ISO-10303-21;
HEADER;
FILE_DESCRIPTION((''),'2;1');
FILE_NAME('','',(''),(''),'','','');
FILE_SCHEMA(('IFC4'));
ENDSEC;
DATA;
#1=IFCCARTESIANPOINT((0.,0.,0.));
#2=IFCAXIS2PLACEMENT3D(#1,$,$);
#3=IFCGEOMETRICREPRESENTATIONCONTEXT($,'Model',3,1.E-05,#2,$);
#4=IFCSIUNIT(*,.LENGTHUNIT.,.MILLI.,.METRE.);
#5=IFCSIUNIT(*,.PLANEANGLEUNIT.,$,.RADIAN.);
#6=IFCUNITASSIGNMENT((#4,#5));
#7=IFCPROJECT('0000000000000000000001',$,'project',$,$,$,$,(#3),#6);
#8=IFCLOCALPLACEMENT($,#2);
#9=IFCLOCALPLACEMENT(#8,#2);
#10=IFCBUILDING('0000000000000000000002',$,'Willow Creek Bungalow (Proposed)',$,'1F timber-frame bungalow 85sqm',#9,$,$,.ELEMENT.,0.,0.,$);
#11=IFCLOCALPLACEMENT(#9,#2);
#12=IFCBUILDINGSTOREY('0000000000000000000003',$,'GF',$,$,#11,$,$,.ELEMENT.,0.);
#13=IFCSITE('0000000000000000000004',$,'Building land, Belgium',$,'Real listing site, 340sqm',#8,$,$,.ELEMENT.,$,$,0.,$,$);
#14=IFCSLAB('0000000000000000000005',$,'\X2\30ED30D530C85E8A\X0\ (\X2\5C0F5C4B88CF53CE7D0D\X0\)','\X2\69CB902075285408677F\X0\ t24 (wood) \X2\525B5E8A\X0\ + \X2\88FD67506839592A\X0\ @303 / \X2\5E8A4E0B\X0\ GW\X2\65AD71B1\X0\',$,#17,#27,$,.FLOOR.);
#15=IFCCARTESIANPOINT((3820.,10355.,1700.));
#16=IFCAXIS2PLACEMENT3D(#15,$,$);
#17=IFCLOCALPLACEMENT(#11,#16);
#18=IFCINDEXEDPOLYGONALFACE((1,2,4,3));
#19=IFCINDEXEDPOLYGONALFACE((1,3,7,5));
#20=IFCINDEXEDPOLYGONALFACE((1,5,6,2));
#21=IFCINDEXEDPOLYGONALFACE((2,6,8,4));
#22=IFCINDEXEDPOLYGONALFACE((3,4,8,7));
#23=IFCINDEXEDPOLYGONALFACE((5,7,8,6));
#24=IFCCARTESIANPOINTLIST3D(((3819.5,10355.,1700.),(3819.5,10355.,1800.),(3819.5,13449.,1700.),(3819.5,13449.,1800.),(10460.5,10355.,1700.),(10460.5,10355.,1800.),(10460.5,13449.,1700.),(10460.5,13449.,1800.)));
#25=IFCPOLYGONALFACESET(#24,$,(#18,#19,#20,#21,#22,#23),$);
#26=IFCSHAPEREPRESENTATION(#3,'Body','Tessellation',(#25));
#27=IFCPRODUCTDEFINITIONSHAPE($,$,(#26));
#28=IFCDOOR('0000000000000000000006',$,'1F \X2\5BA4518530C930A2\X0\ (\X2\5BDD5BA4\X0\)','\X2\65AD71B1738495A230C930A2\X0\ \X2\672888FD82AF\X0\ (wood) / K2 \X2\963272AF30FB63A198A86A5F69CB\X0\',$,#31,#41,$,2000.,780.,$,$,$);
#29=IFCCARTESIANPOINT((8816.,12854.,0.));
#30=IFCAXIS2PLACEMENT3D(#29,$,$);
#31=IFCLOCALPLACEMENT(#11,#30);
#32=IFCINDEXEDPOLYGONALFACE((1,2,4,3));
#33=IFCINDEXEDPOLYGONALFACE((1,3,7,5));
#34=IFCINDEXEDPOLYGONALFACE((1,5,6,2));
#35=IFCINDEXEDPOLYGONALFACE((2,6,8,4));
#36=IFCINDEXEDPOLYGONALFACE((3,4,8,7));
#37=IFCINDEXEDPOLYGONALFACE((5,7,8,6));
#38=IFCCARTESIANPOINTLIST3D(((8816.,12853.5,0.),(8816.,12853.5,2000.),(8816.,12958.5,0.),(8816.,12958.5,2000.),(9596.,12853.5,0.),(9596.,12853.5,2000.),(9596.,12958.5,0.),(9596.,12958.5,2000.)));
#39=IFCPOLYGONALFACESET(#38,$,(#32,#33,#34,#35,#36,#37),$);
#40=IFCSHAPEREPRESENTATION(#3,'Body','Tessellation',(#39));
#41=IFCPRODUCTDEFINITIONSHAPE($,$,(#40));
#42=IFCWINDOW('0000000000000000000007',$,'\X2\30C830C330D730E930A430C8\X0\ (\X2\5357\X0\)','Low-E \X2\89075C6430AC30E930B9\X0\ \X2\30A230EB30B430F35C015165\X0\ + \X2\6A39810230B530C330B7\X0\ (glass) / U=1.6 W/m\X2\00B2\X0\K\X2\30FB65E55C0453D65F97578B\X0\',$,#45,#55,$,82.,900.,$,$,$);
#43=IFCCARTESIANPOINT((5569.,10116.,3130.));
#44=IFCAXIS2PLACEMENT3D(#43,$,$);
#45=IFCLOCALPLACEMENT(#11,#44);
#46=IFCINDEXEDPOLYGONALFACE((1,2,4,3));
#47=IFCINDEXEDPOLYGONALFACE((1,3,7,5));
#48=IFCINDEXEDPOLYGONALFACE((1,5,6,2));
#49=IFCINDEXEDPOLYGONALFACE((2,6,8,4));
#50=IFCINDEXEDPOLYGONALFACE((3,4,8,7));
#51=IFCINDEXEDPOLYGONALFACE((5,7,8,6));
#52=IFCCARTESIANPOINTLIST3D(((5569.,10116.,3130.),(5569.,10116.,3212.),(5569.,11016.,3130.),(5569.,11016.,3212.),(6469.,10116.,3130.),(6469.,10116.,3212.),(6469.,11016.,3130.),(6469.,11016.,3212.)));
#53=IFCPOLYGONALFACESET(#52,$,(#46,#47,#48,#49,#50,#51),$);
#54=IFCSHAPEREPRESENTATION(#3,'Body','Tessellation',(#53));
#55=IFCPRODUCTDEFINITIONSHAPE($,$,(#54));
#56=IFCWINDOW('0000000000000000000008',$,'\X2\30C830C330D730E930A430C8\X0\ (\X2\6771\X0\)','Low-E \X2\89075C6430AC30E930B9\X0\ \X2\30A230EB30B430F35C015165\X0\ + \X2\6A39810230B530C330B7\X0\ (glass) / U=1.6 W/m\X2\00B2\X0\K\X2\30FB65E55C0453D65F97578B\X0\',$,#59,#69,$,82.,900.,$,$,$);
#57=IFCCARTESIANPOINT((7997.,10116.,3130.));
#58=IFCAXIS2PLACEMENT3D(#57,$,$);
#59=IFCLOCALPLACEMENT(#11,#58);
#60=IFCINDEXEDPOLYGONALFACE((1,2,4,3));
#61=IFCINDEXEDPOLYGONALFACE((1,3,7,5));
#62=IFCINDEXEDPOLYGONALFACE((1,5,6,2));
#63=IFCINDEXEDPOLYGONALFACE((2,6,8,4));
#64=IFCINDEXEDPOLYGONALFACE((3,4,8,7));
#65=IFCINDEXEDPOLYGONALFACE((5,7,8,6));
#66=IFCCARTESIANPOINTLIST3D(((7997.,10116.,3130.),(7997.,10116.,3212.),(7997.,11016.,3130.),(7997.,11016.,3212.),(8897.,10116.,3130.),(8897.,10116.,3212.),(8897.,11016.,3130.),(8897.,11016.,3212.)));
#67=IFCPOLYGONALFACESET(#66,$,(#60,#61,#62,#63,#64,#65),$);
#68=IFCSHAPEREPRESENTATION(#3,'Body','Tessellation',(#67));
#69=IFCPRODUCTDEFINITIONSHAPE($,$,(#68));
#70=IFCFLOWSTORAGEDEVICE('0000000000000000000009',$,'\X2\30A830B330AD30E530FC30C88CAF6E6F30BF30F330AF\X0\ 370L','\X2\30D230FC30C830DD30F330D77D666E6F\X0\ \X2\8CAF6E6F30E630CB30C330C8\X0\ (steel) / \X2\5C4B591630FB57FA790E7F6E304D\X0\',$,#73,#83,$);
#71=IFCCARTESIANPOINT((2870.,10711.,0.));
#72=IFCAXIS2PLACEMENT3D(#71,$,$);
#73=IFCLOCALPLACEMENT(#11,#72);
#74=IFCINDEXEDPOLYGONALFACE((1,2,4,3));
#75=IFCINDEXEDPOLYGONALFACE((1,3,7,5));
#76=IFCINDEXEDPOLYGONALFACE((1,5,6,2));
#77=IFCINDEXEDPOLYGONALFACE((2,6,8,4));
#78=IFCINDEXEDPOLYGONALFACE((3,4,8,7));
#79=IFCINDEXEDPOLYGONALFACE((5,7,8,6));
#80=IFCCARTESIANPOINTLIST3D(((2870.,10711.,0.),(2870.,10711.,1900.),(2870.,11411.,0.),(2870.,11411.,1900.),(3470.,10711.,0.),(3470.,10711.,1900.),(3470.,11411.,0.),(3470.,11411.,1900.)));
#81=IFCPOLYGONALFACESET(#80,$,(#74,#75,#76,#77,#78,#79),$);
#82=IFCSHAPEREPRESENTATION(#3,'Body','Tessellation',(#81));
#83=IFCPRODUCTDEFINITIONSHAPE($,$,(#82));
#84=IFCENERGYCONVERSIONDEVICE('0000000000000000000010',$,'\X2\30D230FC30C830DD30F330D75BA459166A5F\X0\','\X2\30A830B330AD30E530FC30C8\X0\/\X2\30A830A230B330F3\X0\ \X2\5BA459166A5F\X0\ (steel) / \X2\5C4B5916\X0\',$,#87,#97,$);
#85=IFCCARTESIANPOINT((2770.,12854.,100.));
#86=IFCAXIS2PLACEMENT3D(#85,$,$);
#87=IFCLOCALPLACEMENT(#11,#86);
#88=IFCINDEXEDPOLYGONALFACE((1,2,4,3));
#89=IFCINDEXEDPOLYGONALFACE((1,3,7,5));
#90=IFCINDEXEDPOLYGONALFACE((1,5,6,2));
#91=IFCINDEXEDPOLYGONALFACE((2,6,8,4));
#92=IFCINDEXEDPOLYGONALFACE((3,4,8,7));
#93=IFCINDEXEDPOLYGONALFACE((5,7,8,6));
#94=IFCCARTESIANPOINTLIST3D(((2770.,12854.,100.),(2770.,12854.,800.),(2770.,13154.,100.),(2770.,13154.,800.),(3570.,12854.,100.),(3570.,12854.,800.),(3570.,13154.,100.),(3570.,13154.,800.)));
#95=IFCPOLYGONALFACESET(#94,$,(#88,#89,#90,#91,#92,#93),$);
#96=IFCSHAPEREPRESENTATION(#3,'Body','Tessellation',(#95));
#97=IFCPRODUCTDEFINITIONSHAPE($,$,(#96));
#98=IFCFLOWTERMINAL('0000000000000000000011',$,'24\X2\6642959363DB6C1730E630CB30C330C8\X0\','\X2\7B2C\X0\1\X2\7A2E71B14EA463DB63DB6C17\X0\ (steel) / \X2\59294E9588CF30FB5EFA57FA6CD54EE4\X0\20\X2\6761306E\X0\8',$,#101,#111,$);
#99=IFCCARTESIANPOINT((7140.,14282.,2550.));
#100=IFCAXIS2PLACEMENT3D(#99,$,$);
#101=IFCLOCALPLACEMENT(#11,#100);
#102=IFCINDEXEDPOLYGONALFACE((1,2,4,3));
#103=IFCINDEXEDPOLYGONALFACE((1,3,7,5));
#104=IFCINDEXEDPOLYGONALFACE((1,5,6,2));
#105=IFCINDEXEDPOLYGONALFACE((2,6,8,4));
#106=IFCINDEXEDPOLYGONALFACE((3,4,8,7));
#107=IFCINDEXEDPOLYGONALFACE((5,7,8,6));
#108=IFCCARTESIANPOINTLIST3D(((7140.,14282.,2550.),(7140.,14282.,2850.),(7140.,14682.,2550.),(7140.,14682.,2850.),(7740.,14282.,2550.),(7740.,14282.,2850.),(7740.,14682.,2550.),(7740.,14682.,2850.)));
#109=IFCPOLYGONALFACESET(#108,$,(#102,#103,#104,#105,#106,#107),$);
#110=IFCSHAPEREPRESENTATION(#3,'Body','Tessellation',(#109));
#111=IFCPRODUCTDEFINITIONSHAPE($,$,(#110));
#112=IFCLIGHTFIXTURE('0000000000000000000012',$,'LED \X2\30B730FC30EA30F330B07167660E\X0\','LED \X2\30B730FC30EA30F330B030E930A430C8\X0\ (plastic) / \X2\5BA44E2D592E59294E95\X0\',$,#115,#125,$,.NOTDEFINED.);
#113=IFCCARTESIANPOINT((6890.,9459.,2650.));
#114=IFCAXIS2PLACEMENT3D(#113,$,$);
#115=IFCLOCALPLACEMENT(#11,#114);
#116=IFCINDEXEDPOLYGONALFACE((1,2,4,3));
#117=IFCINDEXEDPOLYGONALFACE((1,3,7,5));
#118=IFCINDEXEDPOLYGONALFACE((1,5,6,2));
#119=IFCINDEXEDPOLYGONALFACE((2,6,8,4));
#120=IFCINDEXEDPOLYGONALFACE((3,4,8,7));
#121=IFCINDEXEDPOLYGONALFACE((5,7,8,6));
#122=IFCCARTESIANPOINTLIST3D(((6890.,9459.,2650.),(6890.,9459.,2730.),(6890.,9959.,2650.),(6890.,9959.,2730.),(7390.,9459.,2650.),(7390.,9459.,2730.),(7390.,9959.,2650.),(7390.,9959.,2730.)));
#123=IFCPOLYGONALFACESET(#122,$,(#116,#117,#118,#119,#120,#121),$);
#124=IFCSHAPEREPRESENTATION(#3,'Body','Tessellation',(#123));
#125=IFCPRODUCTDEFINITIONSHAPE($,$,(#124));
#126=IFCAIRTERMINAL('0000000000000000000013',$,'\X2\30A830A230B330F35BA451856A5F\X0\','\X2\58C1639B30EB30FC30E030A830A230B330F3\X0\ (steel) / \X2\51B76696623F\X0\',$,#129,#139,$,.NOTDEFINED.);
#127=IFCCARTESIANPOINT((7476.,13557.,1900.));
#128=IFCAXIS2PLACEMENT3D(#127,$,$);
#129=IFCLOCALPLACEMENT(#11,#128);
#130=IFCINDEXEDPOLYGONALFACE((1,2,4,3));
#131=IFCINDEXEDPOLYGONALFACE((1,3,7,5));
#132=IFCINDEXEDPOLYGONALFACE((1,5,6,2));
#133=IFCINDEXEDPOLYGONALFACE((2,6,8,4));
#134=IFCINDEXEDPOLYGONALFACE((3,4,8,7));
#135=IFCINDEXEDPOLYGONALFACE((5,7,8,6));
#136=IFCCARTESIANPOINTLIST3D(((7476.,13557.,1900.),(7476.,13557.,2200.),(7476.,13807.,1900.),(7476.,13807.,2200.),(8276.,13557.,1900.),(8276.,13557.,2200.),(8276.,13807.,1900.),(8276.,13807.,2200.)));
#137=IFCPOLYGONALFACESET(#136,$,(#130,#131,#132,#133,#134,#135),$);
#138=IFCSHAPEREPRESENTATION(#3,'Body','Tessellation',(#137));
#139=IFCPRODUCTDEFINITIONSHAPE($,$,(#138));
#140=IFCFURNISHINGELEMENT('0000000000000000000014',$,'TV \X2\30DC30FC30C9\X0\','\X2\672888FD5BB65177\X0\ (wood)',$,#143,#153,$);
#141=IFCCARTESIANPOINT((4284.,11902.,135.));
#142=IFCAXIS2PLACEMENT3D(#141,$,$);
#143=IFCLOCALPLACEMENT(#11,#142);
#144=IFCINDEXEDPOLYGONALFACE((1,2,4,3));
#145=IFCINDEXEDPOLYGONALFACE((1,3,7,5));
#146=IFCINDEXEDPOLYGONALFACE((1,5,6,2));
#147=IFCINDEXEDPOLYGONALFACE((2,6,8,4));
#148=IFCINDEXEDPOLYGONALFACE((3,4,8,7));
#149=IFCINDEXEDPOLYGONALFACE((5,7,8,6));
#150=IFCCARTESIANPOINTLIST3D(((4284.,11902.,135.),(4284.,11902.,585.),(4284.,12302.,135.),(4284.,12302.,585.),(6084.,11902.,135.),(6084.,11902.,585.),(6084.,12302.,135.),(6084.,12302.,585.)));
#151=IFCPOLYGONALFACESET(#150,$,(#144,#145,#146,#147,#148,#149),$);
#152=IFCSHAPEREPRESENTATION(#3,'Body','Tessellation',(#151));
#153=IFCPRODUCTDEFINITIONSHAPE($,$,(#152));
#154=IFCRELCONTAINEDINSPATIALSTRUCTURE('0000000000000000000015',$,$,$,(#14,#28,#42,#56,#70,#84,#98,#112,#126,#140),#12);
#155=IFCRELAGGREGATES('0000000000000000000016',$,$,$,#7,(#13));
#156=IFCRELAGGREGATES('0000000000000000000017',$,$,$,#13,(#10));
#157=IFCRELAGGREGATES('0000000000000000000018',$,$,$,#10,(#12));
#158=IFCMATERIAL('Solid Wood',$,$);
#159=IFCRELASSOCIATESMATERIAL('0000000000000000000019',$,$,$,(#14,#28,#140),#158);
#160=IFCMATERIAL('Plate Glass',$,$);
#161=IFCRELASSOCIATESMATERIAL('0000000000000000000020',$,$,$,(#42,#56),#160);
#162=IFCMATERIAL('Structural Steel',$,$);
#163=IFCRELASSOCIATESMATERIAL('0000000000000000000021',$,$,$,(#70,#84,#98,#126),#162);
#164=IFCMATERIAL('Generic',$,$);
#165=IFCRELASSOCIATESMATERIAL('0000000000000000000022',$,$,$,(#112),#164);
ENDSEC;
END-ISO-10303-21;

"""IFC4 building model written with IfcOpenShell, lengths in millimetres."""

from ifc_helpers import new_model, si_unit, frame, frame_2d, origin, place, context, project, spatial, rectangle, extrude, material, element, save


model = new_model("IFC4")

# Units and contexts
model_context = context("Model", 3, precision=1e-05, world=origin())
ifc_project = project(units=[si_unit("LENGTHUNIT", "METRE", prefix="MILLI"), si_unit("PLANEANGLEUNIT", "RADIAN")], contexts=[model_context])

# Site, building, storey
site_placement = place(None, origin())
site = spatial("IfcSite", under=ifc_project, at=site_placement, Name="Building land, Belgium", ObjectType="Real listing site, 340sqm", CompositionType="ELEMENT", RefElevation=0.0)
building_placement = place(site_placement, origin())
building = spatial("IfcBuilding", under=site, at=building_placement, Name="Willow Creek Bungalow (Proposed)", ObjectType="1F timber-frame bungalow 85sqm", CompositionType="ELEMENT", ElevationOfRefHeight=0.0, ElevationOfTerrain=0.0)
storey_placement = place(building_placement, origin())
storey = spatial("IfcBuildingStorey", under=building, at=storey_placement, Name="GF", CompositionType="ELEMENT", Elevation=0.0)

# Shared definitions
ifc_material_1 = material(Name="Solid Wood")

# Slab
slab_placement = place(storey_placement, frame((3820.0, 10355.0, 1700.0)))
element("IfcSlab", 1, at=slab_placement, inside=storey, material=ifc_material_1, Name="ロフト床 (小屋裏収納)", Description="構造用合板 t24 (wood) 剛床 + 製材根太 @303 / 床下 GW断熱", PredefinedType="FLOOR", context=model_context, shape_type="SweptSolid", body=[
    extrude(rectangle(XDim=6641.0, YDim=3094.0, at=frame_2d((3320.0, 1547.0))), frame((3820.0, 10355.0, 1700.0)), (0.0, 0.0, 1.0), 100.0),
])

# Door
door_1_placement = place(storey_placement, frame((8816.0, 12854.0, 0.0)))
element("IfcDoor", 2, at=door_1_placement, inside=storey, material=ifc_material_1, Name="1F 室内ドア (寝室)", Description="断熱玄関ドア 木製芯 (wood) / K2 防犯・採風機構", OverallHeight=2000.0, OverallWidth=780.0, context=model_context, shape_type="SweptSolid", body=[
    extrude(rectangle(XDim=780.0, YDim=105.0, at=frame_2d((390.0, 52.0))), frame((8816.0, 12854.0, 0.0)), (0.0, 0.0, 1.0), 2000.0),
])

# Windows
ifc_material_2 = material(Name="Plate Glass")
window_1_placement = place(storey_placement, frame((5569.0, 10116.0, 3130.0)))
element("IfcWindow", 3, at=window_1_placement, inside=storey, material=ifc_material_2, Name="トップライト (南)", Description="Low-E 複層ガラス アルゴン封入 + 樹脂サッシ (glass) / U=1.6 W/m²K・日射取得型", OverallHeight=82.0, OverallWidth=900.0, context=model_context, shape_type="SweptSolid", body=[
    extrude(rectangle(XDim=900.0, YDim=900.0, at=frame_2d((450.0, 450.0))), frame((5569.0, 10116.0, 3130.0)), (0.0, 0.0, 1.0), 82.0),
])
window_2_placement = place(storey_placement, frame((7997.0, 10116.0, 3130.0)))
element("IfcWindow", 4, at=window_2_placement, inside=storey, material=ifc_material_2, Name="トップライト (東)", Description="Low-E 複層ガラス アルゴン封入 + 樹脂サッシ (glass) / U=1.6 W/m²K・日射取得型", OverallHeight=82.0, OverallWidth=900.0, context=model_context, shape_type="SweptSolid", body=[
    extrude(rectangle(XDim=900.0, YDim=900.0, at=frame_2d((450.0, 450.0))), frame((7997.0, 10116.0, 3130.0)), (0.0, 0.0, 1.0), 82.0),
])

# Flow storage device
ifc_material_3 = material(Name="Structural Steel")
flow_storage_device_placement = place(storey_placement, frame((2870.0, 10711.0, 0.0)))
element("IfcFlowStorageDevice", 5, at=flow_storage_device_placement, inside=storey, material=ifc_material_3, Name="エコキュート貯湯タンク 370L", Description="ヒートポンプ給湯 貯湯ユニット (steel) / 屋外・基礎置き", context=model_context, shape_type="SweptSolid", body=[
    extrude(rectangle(XDim=600.0, YDim=700.0, at=frame_2d((300.0, 350.0))), frame((2870.0, 10711.0, 0.0)), (0.0, 0.0, 1.0), 1900.0),
])

# Energy conversion device
energy_conversion_device_placement = place(storey_placement, frame((2770.0, 12854.0, 100.0)))
element("IfcEnergyConversionDevice", 6, at=energy_conversion_device_placement, inside=storey, material=ifc_material_3, Name="ヒートポンプ室外機", Description="エコキュート/エアコン 室外機 (steel) / 屋外", context=model_context, shape_type="SweptSolid", body=[
    extrude(rectangle(XDim=800.0, YDim=300.0, at=frame_2d((400.0, 150.0))), frame((2770.0, 12854.0, 100.0)), (0.0, 0.0, 1.0), 700.0),
])

# Flow terminal
flow_terminal_placement = place(storey_placement, frame((7140.0, 14282.0, 2550.0)))
element("IfcFlowTerminal", 7, at=flow_terminal_placement, inside=storey, material=ifc_material_3, Name="24時間換気ユニット", Description="第1種熱交換換気 (steel) / 天井裏・建基法令20条の8", context=model_context, shape_type="SweptSolid", body=[
    extrude(rectangle(XDim=600.0, YDim=400.0, at=frame_2d((300.0, 200.0))), frame((7140.0, 14282.0, 2550.0)), (0.0, 0.0, 1.0), 300.0),
])

# Light fixture
ifc_material_4 = material(Name="Generic")
light_fixture_placement = place(storey_placement, frame((6890.0, 9459.0, 2650.0)))
element("IfcLightFixture", 8, at=light_fixture_placement, inside=storey, material=ifc_material_4, Name="LED シーリング照明", Description="LED シーリングライト (plastic) / 室中央天井", PredefinedType="NOTDEFINED", context=model_context, shape_type="SweptSolid", body=[
    extrude(rectangle(XDim=500.0, YDim=500.0, at=frame_2d((250.0, 250.0))), frame((6890.0, 9459.0, 2650.0)), (0.0, 0.0, 1.0), 80.0),
])

# Air terminal
air_terminal_placement = place(storey_placement, frame((7476.0, 13557.0, 1900.0)))
element("IfcAirTerminal", 9, at=air_terminal_placement, inside=storey, material=ifc_material_3, Name="エアコン室内機", Description="壁掛ルームエアコン (steel) / 冷暖房", PredefinedType="NOTDEFINED", context=model_context, shape_type="SweptSolid", body=[
    extrude(rectangle(XDim=800.0, YDim=250.0, at=frame_2d((400.0, 125.0))), frame((7476.0, 13557.0, 1900.0)), (0.0, 0.0, 1.0), 300.0),
])

# Furnishing element
furnishing_placement = place(storey_placement, frame((4284.0, 11902.0, 135.0)))
element("IfcFurnishingElement", 10, at=furnishing_placement, inside=storey, material=ifc_material_1, Name="TV ボード", Description="木製家具 (wood)", context=model_context, shape_type="SweptSolid", body=[
    extrude(rectangle(XDim=1800.0, YDim=400.0, at=frame_2d((900.0, 200.0))), frame((4284.0, 11902.0, 135.0)), (0.0, 0.0, 1.0), 450.0),
])

save(model, "model.ifc")
